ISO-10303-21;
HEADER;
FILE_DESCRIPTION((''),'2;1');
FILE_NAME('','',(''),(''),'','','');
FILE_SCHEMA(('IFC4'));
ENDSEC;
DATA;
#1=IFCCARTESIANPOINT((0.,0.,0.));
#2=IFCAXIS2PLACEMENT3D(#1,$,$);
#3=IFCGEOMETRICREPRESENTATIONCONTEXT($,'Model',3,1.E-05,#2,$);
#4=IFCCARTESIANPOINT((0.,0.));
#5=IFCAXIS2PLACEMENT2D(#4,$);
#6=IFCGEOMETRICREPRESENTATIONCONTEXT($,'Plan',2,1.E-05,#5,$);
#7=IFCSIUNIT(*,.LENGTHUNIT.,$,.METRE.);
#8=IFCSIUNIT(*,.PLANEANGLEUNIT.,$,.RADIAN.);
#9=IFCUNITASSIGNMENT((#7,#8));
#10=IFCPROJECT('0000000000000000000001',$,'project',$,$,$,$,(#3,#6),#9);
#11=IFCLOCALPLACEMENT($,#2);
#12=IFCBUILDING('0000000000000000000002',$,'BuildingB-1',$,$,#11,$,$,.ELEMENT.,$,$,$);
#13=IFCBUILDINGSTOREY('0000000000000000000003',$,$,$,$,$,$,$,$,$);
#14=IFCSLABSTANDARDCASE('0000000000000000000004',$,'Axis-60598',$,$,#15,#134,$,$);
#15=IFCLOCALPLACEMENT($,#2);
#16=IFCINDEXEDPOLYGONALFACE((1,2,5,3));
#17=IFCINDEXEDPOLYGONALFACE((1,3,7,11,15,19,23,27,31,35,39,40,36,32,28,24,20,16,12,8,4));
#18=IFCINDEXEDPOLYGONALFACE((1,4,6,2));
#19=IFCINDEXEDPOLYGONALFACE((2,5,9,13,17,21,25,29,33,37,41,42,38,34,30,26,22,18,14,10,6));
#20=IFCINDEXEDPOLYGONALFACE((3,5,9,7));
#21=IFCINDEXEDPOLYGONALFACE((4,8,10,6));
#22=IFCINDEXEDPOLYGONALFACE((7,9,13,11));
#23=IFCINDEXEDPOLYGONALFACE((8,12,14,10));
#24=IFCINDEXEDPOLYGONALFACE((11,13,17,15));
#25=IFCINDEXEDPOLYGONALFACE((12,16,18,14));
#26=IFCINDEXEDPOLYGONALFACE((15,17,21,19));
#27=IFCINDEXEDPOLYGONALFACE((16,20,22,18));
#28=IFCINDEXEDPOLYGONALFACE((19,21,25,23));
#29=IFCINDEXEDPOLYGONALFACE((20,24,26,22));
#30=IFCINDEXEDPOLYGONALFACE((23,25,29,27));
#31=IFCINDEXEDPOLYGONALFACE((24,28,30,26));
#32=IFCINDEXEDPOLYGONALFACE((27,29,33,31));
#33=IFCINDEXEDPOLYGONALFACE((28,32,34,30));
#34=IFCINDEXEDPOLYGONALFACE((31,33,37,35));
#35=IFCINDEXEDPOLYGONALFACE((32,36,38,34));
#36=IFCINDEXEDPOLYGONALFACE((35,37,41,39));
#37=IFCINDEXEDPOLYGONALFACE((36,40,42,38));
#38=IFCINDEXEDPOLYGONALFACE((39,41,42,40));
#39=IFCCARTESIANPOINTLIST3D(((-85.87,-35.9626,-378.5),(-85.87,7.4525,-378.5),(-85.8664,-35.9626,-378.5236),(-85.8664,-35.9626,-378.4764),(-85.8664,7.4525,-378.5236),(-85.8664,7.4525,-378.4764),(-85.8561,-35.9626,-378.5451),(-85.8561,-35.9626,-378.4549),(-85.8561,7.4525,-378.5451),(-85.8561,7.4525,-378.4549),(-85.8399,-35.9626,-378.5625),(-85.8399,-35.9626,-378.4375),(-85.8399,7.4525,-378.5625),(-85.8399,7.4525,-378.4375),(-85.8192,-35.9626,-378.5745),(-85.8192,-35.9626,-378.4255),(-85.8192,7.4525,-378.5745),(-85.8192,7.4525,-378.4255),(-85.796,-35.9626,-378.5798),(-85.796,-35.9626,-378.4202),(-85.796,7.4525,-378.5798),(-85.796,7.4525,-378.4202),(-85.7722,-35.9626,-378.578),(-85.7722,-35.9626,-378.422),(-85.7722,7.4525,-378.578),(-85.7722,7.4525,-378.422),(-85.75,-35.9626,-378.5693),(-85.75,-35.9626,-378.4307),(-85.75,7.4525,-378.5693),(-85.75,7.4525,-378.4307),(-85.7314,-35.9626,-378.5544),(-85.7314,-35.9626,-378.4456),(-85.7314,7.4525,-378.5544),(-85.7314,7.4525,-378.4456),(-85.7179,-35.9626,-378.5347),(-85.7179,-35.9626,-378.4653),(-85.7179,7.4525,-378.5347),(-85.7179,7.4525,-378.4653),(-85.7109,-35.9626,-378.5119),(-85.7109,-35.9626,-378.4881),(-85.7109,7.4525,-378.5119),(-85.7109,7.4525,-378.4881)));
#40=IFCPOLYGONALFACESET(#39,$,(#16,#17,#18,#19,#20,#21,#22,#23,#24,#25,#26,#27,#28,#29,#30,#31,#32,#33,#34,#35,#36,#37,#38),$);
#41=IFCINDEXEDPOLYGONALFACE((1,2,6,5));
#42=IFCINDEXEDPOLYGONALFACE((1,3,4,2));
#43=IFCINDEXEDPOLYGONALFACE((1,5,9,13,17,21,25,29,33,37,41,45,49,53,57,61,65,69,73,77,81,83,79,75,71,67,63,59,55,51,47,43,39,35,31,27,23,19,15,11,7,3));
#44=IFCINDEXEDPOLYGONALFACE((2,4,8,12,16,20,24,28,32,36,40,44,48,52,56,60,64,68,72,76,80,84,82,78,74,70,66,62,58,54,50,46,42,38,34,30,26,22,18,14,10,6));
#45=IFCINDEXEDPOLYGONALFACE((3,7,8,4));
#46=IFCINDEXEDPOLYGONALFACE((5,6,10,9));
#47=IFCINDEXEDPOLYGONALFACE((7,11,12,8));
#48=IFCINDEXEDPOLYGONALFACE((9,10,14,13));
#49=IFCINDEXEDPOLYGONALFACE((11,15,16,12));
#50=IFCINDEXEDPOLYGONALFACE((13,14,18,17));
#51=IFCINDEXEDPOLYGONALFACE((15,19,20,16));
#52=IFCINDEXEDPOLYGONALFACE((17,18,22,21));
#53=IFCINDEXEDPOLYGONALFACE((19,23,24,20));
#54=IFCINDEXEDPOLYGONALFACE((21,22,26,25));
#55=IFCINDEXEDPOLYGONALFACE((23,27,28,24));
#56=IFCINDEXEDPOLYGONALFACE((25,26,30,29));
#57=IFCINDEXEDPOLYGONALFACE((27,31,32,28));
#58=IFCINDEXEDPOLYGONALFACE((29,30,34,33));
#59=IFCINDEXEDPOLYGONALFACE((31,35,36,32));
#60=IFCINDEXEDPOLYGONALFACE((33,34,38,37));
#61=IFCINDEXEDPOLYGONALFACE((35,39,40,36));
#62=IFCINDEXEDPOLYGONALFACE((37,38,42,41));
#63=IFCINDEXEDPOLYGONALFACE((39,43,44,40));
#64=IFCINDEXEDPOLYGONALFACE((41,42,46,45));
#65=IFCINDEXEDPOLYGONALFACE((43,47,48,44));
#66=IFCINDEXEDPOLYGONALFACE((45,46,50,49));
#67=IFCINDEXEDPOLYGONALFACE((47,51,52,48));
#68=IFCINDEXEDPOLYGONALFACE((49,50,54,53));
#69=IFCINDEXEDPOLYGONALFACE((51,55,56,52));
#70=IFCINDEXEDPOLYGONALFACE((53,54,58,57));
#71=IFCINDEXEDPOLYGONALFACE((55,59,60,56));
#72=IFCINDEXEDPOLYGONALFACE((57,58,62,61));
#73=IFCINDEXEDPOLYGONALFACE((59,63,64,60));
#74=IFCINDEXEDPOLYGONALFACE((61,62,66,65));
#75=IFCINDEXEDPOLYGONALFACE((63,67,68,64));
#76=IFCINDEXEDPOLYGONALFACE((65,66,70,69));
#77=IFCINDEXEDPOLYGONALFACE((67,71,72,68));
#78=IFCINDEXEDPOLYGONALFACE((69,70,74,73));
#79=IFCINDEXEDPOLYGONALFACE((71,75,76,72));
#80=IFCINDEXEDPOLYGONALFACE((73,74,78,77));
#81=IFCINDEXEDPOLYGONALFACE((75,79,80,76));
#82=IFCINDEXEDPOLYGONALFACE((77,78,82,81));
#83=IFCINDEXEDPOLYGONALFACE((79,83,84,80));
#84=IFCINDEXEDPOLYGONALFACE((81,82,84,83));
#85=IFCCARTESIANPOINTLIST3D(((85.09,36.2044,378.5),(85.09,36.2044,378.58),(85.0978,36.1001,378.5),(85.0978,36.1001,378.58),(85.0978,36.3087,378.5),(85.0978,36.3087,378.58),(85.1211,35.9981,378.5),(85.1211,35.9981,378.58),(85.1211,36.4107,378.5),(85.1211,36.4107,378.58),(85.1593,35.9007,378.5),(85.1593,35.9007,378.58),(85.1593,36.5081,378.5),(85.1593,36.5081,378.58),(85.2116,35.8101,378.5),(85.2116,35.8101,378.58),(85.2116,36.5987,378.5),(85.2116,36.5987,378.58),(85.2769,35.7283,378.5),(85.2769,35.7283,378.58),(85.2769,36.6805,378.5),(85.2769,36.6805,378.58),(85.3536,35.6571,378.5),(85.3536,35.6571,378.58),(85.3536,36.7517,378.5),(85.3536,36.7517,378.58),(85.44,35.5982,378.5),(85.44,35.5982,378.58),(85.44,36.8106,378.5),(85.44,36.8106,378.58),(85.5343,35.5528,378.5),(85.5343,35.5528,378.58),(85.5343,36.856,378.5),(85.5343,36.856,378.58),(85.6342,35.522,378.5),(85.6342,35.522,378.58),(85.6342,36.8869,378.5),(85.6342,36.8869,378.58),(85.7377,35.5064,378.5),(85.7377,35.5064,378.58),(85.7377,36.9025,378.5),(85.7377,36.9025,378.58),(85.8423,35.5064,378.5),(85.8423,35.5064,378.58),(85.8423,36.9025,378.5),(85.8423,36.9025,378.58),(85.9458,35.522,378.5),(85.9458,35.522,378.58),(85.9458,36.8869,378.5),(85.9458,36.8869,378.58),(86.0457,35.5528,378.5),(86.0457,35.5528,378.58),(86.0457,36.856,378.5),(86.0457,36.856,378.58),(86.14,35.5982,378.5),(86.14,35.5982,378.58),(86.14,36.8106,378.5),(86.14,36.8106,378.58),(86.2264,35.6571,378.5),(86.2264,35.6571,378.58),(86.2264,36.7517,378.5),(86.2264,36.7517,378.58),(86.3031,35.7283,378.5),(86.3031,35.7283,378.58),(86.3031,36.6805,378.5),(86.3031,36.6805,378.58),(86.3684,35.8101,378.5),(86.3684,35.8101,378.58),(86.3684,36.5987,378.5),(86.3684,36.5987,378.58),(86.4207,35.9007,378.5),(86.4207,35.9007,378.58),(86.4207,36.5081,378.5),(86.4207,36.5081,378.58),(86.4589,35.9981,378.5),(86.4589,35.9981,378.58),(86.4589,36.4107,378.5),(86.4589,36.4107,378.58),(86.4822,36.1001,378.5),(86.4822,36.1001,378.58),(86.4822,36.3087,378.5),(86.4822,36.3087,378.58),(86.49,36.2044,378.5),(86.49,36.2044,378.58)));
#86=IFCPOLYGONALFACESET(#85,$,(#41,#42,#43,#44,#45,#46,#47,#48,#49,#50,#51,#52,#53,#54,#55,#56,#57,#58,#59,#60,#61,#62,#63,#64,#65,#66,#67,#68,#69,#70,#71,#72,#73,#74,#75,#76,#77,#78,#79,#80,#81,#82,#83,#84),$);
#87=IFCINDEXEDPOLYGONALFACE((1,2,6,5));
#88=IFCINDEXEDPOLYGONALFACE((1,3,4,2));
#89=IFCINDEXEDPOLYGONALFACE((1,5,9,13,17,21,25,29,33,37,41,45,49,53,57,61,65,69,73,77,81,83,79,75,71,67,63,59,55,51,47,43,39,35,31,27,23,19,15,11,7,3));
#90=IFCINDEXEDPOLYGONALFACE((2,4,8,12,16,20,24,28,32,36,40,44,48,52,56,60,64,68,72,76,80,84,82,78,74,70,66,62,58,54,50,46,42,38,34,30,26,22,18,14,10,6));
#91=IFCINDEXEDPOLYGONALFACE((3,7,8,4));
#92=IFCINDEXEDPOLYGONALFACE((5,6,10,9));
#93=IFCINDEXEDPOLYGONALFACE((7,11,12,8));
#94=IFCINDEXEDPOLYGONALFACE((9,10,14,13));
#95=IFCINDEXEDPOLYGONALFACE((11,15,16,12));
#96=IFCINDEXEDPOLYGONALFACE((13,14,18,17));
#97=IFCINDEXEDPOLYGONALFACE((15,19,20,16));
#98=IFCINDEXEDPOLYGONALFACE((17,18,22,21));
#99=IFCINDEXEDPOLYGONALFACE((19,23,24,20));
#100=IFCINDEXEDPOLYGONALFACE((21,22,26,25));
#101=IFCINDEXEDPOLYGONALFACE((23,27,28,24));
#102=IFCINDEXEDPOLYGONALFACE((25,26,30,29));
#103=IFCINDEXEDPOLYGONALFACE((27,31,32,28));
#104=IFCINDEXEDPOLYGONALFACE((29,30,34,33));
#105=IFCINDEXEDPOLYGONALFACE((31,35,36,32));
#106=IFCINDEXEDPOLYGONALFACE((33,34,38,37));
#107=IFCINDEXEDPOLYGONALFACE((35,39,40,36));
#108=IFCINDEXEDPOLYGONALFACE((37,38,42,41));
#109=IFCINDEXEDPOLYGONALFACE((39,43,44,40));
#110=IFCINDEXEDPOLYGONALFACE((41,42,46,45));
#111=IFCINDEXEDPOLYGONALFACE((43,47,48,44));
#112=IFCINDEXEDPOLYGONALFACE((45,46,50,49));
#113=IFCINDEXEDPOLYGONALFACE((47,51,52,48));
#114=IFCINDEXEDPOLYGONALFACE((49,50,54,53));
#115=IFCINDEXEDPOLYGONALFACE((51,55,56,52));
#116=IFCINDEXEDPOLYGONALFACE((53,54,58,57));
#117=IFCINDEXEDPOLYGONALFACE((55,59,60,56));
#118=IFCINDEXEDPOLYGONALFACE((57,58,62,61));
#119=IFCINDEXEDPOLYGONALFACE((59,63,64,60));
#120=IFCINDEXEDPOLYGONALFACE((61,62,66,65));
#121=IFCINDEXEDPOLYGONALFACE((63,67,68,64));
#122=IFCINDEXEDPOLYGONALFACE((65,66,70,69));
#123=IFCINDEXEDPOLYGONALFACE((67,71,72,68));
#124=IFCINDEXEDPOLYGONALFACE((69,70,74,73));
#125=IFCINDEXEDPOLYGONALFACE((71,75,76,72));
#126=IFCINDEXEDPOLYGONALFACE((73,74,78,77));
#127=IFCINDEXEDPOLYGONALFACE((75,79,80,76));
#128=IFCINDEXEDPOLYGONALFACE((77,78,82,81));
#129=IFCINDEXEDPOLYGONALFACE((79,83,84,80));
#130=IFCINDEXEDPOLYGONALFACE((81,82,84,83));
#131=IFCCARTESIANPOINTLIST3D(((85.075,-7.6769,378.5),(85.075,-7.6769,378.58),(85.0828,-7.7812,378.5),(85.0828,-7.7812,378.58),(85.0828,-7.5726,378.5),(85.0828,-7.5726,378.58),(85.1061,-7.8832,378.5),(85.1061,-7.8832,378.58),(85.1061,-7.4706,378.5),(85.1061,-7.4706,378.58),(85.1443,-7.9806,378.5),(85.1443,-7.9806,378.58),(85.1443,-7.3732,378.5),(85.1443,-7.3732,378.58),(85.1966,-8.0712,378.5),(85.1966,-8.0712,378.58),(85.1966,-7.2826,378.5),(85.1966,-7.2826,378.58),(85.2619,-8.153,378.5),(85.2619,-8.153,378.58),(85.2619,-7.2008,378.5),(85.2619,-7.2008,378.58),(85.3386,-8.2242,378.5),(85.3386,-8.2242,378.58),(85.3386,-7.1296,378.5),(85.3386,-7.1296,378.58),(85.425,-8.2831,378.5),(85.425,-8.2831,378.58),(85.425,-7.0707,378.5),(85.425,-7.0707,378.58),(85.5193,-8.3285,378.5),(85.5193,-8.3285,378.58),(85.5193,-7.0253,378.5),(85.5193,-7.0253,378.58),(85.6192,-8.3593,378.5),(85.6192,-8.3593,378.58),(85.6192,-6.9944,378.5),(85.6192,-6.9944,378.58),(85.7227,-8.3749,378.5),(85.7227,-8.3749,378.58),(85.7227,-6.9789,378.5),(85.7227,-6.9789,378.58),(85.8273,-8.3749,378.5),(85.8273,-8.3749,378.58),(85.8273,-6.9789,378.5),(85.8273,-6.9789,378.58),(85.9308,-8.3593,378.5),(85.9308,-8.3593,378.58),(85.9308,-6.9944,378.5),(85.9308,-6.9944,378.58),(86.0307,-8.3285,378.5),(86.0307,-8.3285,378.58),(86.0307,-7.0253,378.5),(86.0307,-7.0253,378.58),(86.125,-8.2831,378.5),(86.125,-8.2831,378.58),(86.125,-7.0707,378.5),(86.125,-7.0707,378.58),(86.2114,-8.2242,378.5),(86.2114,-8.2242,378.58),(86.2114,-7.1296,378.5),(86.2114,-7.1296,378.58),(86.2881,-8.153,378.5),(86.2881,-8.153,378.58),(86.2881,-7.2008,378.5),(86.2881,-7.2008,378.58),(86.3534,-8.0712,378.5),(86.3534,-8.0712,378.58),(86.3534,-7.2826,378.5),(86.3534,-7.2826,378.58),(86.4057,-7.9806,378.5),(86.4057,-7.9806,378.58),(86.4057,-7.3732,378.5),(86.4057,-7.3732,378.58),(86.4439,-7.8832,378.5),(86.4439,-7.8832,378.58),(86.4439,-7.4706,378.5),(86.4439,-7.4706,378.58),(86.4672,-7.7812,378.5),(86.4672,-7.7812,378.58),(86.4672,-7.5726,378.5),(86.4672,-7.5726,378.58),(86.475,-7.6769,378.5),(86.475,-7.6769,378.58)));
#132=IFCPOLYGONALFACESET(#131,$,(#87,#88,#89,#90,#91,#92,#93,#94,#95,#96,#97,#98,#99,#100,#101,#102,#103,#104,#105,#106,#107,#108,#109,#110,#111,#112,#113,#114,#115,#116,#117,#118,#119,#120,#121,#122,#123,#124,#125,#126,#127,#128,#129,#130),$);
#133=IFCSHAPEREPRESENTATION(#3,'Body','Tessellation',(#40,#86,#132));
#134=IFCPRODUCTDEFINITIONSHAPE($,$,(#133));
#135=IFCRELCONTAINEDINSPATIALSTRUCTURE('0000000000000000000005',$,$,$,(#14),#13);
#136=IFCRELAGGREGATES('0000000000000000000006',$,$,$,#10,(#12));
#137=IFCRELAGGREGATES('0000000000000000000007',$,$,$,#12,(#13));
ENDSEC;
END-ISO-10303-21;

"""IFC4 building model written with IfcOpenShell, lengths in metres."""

from ifc_helpers import new_model, entity, si_unit, frame, origin, origin_2d, place, context, project, spatial, circle, extrude, element, save


model = new_model("IFC4")

# Units and contexts
model_context = context("Model", 3, precision=1e-05, world=origin())
plan_context = context("Plan", 2, precision=1e-05, world=origin_2d())
ifc_project = project(units=[si_unit("LENGTHUNIT", "METRE"), si_unit("PLANEANGLEUNIT", "RADIAN")], contexts=[model_context, plan_context])

# Building, storey
building_placement = place(None, origin())
building = spatial("IfcBuilding", under=ifc_project, at=building_placement, Name="BuildingB-1", CompositionType="ELEMENT")
storey = spatial("IfcBuildingStorey", under=building)

# Slab
element("IfcSlabStandardCase", 1, inside=storey, Name="Axis-60598", context=model_context, shape_type="AdvancedSweptSolid", body=[
    entity("IfcSurfaceCurveSweptAreaSolid", entity("IfcCircleProfileDef", "AREA", None, None, 0.08), None, entity("IfcPolyline", [entity("IfcCartesianPoint", [85.79, 35.9626, 378.5]), entity("IfcCartesianPoint", [85.79, -7.4525, 378.5])]), None, None, entity("IfcPlane", entity("IfcAxis2Placement3D", entity("IfcCartesianPoint", [85.79, 35.9626, 378.5]), entity("IfcDirection", [0.0, 0.0, 1.0]), entity("IfcDirection", [1.0, 0.0, 0.0])))),
    extrude(circle(Radius=0.7), frame((85.79, 36.2044, 378.5)), (0.0, 0.0, 1.0), 0.08),
    extrude(circle(Radius=0.7), frame((85.775, -7.6769, 378.5)), (0.0, 0.0, 1.0), 0.08),
])

save(model, "model.ifc")
